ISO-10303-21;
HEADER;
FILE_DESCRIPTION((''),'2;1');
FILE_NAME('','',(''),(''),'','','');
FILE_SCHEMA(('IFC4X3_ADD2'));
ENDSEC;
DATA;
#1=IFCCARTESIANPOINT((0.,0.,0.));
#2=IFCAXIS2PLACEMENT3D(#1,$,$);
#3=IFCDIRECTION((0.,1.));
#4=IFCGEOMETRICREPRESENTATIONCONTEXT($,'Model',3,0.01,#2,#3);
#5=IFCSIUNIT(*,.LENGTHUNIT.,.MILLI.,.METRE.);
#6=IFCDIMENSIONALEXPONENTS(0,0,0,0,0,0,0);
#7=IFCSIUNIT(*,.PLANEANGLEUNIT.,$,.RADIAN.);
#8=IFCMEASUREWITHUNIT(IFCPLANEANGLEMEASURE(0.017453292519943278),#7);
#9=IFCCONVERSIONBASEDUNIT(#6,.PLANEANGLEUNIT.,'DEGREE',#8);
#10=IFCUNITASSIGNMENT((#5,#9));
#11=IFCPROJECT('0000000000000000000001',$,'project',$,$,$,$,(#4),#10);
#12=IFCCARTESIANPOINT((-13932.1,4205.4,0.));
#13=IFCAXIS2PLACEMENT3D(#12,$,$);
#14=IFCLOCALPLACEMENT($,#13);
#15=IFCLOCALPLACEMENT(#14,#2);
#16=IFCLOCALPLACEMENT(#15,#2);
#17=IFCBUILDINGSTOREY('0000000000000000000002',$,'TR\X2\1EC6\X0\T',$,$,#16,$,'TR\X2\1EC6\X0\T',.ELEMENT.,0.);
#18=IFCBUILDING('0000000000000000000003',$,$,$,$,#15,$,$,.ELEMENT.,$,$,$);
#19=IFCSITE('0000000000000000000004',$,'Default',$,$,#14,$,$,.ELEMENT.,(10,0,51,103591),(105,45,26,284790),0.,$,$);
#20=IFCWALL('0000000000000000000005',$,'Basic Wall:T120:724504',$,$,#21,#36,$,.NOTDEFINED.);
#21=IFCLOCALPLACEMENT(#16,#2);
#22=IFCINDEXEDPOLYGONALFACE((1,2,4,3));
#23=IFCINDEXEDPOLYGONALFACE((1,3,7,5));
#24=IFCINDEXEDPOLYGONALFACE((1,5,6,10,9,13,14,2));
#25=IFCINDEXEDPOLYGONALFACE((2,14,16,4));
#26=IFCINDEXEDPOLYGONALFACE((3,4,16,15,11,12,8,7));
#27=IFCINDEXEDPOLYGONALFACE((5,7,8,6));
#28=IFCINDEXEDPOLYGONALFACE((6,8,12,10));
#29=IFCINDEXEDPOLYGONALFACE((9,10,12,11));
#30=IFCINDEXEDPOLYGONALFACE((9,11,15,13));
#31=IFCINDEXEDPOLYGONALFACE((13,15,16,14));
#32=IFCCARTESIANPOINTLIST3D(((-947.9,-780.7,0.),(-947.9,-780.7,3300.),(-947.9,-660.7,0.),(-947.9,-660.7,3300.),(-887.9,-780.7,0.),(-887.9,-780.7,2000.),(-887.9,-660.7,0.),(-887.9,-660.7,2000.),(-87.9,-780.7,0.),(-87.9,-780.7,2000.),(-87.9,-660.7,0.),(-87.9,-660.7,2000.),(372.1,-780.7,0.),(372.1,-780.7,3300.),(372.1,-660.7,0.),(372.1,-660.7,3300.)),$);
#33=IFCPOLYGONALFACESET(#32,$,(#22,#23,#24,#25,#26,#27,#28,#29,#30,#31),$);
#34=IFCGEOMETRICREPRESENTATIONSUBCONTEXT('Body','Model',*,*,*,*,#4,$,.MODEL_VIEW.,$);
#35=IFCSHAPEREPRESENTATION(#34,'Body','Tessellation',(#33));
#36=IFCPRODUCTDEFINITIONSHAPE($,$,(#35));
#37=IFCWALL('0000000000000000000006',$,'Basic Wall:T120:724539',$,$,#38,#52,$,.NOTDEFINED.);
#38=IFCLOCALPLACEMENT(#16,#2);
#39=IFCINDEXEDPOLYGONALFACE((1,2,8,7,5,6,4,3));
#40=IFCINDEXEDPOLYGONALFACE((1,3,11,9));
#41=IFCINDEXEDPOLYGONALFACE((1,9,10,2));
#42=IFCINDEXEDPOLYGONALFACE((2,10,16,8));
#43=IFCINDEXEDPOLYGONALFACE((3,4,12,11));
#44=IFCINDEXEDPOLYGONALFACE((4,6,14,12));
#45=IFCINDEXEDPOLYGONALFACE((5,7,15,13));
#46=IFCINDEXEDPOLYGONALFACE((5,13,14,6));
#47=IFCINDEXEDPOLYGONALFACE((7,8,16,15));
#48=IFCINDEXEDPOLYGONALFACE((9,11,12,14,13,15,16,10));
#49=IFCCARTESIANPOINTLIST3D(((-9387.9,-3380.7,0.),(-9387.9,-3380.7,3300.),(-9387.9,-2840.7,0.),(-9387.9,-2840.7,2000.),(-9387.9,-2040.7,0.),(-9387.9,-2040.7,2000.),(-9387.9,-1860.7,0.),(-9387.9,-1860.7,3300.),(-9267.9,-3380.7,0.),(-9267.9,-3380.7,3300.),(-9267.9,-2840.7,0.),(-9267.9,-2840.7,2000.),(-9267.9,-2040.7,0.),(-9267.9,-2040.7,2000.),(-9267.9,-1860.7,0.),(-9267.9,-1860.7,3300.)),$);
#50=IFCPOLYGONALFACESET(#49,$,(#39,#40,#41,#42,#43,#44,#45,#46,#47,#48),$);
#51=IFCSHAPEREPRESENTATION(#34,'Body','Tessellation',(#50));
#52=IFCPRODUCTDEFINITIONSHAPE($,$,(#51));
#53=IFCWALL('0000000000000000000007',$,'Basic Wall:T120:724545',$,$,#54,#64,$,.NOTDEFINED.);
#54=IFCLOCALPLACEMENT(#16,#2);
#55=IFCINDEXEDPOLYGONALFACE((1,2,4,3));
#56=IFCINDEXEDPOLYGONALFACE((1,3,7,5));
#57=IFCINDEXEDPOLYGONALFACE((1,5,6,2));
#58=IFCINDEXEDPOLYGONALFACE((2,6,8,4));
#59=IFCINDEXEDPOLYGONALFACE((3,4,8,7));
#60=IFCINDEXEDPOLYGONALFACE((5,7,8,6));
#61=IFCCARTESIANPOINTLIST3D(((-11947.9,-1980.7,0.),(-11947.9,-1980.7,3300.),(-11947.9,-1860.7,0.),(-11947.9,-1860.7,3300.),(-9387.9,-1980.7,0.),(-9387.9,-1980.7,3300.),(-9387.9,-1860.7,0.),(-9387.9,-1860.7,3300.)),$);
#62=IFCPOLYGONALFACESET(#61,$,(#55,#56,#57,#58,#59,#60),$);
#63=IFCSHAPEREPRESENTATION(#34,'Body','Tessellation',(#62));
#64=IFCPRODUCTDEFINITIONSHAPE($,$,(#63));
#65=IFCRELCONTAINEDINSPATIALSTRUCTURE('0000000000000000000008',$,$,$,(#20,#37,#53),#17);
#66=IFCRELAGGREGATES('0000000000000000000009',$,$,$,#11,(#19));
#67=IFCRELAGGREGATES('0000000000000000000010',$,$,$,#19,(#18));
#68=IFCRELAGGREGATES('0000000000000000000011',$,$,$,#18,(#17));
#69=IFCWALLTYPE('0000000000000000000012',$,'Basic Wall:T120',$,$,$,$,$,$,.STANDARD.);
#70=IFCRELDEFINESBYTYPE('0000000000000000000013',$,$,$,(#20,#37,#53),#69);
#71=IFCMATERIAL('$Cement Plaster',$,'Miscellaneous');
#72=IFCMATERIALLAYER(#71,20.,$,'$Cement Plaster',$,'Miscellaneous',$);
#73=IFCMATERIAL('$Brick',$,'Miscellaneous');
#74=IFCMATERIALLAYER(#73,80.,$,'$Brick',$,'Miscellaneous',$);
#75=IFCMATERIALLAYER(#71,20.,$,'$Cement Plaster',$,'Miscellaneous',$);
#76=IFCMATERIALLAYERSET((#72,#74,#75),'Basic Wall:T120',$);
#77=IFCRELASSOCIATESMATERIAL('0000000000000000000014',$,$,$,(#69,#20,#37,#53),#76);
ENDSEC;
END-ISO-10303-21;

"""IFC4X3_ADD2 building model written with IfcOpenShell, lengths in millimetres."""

from ifc_helpers import new_model, entity, si_unit, converted_unit, direction, frame, frame_2d, origin, place, context, subcontext, project, spatial, rectangle, extrude, material, layer, layer_set, type_object, element, save


model = new_model("IFC4X3_ADD2")

# Units and contexts
model_context = context("Model", 3, precision=0.01, world=origin(), true_north=direction((0.0, 1.0)))
body_context = subcontext(model_context, "Body", "Model", "MODEL_VIEW")
ifc_project = project(units=[si_unit("LENGTHUNIT", "METRE", prefix="MILLI"), converted_unit("PLANEANGLEUNIT", "DEGREE", entity("IfcPlaneAngleMeasure", 0.017453292519943278), si_unit("PLANEANGLEUNIT", "RADIAN"), dimensions=[0, 0, 0, 0, 0, 0, 0])], contexts=[model_context])

# Site, building, storey
site_placement = place(None, frame((-13932.1, 4205.4, 0.0)))
site = spatial("IfcSite", under=ifc_project, at=site_placement, Name="Default", CompositionType="ELEMENT", RefLatitude=(10, 0, 51, 103591), RefLongitude=(105, 45, 26, 284790), RefElevation=0.0)
building_placement = place(site_placement, origin())
building = spatial("IfcBuilding", under=site, at=building_placement, CompositionType="ELEMENT")
storey_placement = place(building_placement, origin())
storey = spatial("IfcBuildingStorey", under=building, at=storey_placement, Name="TRỆT", LongName="TRỆT", CompositionType="ELEMENT", Elevation=0.0)

# Shared definitions
ifc_material_1 = material(Name="$Cement Plaster", Category="Miscellaneous")
ifc_layer_1 = layer(ifc_material_1, 20.0, Name="$Cement Plaster", Category="Miscellaneous")
ifc_material_2 = material(Name="$Brick", Category="Miscellaneous")
ifc_layer_2 = layer(ifc_material_2, 80.0, Name="$Brick", Category="Miscellaneous")
ifc_layer_3 = layer(ifc_material_1, 20.0, Name="$Cement Plaster", Category="Miscellaneous")
ifc_layer_set_1 = layer_set([ifc_layer_1, ifc_layer_2, ifc_layer_3], Name="Basic Wall:T120")
wall_type = type_object("IfcWallType", Name="Basic Wall:T120", PredefinedType="STANDARD", material=ifc_layer_set_1)

# Walls, openings
wall_1_placement = place(storey_placement, frame((-947.9, -720.7, 0.0)))
wall_1 = element("IfcWall", 1, at=wall_1_placement, inside=storey, type_object=wall_type, material=ifc_layer_set_1, Name="Basic Wall:T120:724504", PredefinedType="NOTDEFINED", context=body_context, shape_type="SweptSolid", body=[
    extrude(rectangle(XDim=1320.0, YDim=120.0, at=frame_2d((660.0, 0.0), x_axis=(-1.0, 0.0))), origin(), (0.0, 0.0, 1.0), 3300.0),
])
opening_1_placement = place(wall_1_placement, frame((860.0, 60.0, 0.0)))
element("IfcOpeningElement", 2, at=opening_1_placement, cuts=wall_1, PredefinedType="OPENING", context=body_context, shape_type="SweptSolid", body=[
    extrude(rectangle(XDim=2000.0, YDim=800.0, at=frame_2d((1000.0, 400.0), x_axis=(1.0, 0.0))), frame((0.0, 0.0, 0.0), z_axis=(0.0, -1.0, 0.0), x_axis=(0.0, 0.0, 1.0)), (0.0, 0.0, 1.0), 120.0),
])
wall_2_placement = place(storey_placement, frame((-9327.9, -3380.7, 0.0), z_axis=(0.0, 0.0, 1.0), x_axis=(0.0, 1.0, 0.0)))
wall_2 = element("IfcWall", 3, at=wall_2_placement, inside=storey, type_object=wall_type, material=ifc_layer_set_1, Name="Basic Wall:T120:724539", PredefinedType="NOTDEFINED", context=body_context, shape_type="SweptSolid", body=[
    extrude(rectangle(XDim=1520.0, YDim=120.0, at=frame_2d((760.0, 0.0), x_axis=(-1.0, 0.0))), origin(), (0.0, 0.0, 1.0), 3300.0),
])
opening_2_placement = place(wall_2_placement, frame((540.0, -60.0, 0.0)))
element("IfcOpeningElement", 4, at=opening_2_placement, cuts=wall_2, PredefinedType="OPENING", context=body_context, shape_type="SweptSolid", body=[
    extrude(rectangle(XDim=2000.0, YDim=800.0, at=frame_2d((1000.0, 400.0), x_axis=(1.0, 0.0))), frame((0.0, 0.0, 0.0), z_axis=(0.0, 1.0, 0.0), x_axis=(0.0, 0.0, 1.0)), (0.0, 0.0, 1.0), 120.0),
])

# Wall
wall_3_placement = place(storey_placement, frame((-11947.9, -1920.7, 0.0)))
element("IfcWall", 5, at=wall_3_placement, inside=storey, type_object=wall_type, material=ifc_layer_set_1, Name="Basic Wall:T120:724545", PredefinedType="NOTDEFINED", context=body_context, shape_type="SweptSolid", body=[
    extrude(rectangle(XDim=2560.0, YDim=120.0, at=frame_2d((1280.0, 0.0), x_axis=(-1.0, 0.0))), origin(), (0.0, 0.0, 1.0), 3300.0),
])

save(model, "model.ifc")
